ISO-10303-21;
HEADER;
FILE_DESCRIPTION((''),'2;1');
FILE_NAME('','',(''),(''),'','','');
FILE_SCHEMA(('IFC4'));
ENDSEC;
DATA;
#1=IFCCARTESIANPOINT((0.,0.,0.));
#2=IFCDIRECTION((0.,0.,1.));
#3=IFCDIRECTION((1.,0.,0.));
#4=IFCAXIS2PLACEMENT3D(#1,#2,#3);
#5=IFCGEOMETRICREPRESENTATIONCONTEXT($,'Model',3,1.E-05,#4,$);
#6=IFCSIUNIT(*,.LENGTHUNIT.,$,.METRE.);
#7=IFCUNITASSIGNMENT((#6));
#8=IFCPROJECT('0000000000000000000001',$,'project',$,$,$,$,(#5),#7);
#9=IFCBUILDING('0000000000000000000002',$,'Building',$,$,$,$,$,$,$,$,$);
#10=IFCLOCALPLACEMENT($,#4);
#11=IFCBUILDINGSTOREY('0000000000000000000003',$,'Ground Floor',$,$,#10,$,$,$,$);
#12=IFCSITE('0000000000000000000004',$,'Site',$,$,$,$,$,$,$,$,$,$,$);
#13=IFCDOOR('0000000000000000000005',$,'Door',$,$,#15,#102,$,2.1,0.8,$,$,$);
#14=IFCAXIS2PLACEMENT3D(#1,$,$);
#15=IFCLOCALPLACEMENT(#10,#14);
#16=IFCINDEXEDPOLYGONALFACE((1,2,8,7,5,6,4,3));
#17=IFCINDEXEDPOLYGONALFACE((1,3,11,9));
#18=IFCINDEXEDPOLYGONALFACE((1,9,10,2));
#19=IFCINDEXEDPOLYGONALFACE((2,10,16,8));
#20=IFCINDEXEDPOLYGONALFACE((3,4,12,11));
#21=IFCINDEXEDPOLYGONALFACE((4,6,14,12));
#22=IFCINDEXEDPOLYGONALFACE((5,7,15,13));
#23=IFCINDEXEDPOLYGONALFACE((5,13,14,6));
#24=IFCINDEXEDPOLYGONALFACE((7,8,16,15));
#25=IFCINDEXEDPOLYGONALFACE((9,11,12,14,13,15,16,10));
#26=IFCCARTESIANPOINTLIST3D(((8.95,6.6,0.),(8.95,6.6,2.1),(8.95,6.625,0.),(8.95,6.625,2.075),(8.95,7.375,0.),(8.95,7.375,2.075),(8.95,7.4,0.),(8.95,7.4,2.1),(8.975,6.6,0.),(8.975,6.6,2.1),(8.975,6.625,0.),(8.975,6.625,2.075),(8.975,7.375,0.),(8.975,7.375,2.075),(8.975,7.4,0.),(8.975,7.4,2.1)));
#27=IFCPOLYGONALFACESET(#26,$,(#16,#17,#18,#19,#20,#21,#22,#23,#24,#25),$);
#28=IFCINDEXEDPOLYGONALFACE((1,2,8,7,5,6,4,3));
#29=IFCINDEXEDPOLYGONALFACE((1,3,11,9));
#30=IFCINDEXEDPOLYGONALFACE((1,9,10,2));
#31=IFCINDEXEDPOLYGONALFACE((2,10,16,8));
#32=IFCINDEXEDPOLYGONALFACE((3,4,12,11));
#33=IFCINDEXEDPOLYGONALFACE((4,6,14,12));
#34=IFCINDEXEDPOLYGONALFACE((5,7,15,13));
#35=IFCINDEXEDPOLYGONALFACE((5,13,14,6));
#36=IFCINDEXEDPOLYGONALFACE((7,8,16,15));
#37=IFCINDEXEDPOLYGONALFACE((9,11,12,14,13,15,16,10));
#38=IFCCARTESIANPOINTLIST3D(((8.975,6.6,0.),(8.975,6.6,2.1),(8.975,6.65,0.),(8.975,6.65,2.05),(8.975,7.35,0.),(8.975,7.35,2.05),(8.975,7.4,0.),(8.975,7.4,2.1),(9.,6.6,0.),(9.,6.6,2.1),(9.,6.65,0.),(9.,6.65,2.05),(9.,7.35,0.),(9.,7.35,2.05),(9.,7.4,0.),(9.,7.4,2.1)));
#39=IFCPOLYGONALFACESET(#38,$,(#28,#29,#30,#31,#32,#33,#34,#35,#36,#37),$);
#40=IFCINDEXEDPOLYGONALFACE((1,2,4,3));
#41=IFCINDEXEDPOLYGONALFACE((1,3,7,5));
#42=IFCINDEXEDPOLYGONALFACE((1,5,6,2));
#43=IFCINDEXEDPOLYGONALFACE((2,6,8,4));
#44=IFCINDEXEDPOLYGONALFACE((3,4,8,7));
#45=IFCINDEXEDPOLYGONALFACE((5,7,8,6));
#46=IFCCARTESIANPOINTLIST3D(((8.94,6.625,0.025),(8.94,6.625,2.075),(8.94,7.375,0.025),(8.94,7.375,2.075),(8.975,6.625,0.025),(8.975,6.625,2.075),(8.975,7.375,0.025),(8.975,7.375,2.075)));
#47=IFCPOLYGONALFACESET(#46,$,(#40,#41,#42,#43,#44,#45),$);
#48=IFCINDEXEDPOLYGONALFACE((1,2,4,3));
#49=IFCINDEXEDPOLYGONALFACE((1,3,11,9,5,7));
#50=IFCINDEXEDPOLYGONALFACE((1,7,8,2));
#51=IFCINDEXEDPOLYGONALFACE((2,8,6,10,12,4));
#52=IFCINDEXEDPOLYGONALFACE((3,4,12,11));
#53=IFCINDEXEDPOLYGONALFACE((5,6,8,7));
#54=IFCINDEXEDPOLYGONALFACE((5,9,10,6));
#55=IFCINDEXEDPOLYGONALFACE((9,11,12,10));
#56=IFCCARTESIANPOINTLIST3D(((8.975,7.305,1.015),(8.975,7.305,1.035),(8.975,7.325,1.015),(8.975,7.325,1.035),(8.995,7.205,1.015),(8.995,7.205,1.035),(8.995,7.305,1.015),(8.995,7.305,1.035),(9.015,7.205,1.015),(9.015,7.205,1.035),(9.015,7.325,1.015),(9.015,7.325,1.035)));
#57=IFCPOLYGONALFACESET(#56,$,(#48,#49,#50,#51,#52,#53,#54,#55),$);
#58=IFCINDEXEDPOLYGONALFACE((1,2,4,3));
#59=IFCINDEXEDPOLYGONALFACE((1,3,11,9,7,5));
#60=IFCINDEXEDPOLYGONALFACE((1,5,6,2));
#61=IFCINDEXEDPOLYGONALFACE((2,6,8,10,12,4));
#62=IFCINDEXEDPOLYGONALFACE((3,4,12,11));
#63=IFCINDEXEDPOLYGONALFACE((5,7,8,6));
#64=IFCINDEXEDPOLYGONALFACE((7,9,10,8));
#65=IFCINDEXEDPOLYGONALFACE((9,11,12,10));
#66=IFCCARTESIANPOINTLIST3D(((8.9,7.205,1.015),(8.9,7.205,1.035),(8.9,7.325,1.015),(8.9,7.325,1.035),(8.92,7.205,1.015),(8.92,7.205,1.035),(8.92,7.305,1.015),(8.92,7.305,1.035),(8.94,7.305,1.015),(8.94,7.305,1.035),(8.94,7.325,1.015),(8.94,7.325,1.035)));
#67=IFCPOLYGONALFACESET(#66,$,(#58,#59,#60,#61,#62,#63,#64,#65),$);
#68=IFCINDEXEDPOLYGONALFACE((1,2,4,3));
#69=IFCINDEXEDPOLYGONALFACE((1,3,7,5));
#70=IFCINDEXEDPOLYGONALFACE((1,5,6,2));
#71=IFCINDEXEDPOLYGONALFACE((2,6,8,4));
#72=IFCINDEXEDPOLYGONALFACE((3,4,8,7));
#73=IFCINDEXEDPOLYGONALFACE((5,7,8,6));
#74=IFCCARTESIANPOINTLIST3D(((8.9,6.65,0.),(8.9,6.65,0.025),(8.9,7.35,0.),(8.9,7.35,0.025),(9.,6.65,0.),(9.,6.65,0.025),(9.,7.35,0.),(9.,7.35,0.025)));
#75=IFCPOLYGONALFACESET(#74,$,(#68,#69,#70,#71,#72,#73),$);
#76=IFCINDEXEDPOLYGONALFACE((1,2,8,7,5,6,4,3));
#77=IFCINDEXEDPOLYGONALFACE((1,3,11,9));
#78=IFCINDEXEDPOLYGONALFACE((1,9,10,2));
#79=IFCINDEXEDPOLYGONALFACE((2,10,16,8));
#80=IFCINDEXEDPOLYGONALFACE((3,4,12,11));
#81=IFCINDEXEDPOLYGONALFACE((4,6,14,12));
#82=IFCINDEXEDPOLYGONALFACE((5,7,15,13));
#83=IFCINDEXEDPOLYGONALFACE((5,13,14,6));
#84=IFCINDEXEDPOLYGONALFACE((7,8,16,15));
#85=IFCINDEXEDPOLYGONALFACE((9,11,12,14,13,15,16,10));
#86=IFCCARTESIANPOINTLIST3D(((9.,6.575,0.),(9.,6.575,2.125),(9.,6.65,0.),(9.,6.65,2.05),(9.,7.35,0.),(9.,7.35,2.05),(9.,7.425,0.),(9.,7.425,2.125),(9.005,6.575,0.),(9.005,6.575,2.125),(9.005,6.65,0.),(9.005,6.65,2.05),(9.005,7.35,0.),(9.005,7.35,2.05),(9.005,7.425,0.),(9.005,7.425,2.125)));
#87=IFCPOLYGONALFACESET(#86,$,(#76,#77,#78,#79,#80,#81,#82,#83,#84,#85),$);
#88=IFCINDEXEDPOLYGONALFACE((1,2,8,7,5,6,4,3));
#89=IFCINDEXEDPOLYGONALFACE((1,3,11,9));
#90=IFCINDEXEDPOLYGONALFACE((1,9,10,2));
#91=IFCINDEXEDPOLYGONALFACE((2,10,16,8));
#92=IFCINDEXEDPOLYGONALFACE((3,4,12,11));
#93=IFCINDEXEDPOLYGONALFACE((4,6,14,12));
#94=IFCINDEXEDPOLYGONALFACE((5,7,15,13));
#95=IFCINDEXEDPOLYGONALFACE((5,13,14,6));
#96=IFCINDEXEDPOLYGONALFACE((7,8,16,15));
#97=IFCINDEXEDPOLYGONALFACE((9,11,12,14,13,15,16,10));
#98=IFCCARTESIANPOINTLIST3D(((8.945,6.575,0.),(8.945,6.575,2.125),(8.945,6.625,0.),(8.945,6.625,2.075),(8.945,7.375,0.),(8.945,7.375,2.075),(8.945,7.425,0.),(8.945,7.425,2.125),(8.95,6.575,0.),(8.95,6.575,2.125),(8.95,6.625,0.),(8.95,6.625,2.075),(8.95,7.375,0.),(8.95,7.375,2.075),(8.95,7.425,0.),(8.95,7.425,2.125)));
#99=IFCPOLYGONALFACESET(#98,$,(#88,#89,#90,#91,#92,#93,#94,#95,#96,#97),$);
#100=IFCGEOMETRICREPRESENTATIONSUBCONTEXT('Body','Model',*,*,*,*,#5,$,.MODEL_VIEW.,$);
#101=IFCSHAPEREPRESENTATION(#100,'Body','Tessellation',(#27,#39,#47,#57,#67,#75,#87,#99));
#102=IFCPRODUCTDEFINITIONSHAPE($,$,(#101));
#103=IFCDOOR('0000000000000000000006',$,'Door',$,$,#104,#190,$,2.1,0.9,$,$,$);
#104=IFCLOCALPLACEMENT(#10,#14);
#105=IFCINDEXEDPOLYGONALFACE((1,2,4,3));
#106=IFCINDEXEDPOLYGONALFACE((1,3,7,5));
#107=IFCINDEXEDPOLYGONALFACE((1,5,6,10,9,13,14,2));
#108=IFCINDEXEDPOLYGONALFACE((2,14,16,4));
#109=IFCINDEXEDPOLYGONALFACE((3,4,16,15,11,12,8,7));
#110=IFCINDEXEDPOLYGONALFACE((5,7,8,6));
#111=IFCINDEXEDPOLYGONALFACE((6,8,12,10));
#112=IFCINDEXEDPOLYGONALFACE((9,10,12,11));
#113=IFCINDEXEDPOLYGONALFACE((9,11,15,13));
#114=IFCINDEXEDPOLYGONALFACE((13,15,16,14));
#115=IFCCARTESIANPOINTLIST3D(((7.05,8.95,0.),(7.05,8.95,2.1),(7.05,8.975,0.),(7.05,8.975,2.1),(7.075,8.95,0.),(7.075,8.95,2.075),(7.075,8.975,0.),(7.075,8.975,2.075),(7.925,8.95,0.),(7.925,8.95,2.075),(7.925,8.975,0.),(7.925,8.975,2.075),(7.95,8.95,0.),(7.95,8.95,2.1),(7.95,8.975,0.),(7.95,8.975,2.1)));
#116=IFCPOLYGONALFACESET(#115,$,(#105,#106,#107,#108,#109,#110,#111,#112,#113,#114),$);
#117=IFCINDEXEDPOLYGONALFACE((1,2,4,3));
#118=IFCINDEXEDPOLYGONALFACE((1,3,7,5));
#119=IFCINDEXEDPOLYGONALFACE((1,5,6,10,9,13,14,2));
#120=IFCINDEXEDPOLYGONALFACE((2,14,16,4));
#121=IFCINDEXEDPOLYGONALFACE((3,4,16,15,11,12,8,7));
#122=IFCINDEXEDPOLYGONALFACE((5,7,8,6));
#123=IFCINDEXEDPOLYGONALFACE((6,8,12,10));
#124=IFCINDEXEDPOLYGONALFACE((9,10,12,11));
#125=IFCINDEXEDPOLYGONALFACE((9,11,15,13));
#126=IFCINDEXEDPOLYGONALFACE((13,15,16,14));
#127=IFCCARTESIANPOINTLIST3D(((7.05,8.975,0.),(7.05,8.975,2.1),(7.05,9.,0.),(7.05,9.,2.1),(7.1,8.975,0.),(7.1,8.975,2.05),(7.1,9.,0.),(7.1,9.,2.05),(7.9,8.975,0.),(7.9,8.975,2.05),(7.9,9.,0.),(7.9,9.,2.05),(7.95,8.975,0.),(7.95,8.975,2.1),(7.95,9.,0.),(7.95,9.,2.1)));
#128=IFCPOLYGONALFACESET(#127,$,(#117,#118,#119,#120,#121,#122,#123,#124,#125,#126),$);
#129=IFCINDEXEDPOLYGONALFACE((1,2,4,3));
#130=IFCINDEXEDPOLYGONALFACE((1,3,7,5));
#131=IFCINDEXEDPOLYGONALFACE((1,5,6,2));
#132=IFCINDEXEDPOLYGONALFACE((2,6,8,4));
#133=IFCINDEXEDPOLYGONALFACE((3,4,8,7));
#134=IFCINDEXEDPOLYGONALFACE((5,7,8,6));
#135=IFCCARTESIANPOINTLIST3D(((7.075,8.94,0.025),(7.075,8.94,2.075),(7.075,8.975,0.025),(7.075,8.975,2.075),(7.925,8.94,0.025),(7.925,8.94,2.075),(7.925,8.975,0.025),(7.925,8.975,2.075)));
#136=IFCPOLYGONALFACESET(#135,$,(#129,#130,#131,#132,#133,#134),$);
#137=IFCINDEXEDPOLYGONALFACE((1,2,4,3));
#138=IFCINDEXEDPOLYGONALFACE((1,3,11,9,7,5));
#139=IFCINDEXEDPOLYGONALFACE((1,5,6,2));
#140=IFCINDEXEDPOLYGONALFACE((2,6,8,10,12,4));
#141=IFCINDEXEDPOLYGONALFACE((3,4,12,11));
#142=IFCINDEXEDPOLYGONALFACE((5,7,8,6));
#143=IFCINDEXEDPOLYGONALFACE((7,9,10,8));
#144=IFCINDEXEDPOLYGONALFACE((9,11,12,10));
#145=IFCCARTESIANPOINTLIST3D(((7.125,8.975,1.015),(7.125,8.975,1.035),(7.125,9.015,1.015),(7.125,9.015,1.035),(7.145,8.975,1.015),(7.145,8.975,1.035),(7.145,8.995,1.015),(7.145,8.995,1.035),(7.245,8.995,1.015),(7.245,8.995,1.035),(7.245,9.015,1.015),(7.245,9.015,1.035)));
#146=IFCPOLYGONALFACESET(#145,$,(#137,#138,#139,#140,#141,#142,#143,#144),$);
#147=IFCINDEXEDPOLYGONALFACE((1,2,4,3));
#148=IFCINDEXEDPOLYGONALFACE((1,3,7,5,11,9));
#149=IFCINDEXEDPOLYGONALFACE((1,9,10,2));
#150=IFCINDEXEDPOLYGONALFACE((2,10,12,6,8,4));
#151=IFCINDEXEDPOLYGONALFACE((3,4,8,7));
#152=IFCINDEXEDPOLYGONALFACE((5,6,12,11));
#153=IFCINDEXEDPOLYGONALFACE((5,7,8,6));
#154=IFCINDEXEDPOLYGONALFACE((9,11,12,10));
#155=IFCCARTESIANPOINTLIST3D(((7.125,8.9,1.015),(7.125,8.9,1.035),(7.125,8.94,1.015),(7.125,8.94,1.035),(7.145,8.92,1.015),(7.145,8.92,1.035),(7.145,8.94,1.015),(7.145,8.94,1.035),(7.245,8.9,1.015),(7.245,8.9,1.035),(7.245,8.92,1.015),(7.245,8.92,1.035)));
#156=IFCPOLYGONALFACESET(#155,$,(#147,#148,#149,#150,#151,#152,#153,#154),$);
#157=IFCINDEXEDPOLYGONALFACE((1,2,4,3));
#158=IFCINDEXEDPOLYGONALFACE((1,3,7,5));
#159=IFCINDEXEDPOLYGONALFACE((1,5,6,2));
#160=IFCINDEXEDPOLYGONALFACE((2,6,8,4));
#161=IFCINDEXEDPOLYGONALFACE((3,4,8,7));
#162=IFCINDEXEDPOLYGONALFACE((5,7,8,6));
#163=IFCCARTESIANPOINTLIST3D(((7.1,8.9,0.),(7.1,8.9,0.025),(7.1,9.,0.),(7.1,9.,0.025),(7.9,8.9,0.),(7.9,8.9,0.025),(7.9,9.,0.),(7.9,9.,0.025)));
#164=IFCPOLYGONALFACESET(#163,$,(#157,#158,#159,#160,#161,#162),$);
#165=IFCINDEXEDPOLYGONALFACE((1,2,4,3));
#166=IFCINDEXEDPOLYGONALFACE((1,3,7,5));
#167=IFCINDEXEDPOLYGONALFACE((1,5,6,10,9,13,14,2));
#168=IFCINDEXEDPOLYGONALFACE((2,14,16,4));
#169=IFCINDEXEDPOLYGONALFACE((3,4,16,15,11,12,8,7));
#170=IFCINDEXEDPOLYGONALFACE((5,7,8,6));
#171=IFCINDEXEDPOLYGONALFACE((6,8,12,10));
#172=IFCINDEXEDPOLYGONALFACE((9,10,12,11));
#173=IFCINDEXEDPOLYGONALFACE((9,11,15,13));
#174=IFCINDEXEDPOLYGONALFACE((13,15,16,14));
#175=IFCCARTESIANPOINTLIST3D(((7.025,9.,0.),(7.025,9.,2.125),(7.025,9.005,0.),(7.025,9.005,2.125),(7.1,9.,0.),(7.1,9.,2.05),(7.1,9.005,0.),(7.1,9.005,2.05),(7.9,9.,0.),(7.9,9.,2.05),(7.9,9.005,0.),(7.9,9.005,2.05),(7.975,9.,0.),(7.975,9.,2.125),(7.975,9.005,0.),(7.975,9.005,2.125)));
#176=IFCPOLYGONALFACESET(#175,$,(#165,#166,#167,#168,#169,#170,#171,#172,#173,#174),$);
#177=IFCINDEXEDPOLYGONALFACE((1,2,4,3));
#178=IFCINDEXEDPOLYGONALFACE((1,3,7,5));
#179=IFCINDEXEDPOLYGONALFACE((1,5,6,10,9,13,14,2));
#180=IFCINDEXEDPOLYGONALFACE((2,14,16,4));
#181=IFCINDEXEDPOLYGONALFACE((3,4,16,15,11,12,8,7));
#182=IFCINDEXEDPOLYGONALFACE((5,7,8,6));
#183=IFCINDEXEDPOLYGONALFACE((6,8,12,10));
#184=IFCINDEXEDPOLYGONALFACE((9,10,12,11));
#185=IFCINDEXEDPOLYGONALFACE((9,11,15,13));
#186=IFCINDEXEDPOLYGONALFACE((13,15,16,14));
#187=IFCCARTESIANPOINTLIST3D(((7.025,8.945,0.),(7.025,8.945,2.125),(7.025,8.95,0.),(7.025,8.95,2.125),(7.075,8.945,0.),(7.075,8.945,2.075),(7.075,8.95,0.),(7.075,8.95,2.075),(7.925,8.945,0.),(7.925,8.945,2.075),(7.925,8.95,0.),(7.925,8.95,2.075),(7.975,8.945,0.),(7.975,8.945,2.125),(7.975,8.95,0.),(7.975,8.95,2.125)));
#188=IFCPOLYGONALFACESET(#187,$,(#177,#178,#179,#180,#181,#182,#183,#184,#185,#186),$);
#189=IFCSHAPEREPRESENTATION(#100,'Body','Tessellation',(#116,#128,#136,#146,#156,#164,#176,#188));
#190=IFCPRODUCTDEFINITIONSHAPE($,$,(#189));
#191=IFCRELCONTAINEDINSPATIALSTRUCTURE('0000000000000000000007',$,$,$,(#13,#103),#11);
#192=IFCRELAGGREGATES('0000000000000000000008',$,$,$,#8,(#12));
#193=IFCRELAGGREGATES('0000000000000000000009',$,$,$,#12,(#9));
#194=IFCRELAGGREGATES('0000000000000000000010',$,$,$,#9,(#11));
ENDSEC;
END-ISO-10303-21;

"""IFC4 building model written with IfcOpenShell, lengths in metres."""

from ifc_helpers import new_model, si_unit, frame, origin_with_axes, place, context, subcontext, project, spatial, line, indexed_curve, outline, extrude, element, save


model = new_model("IFC4")

# Units and contexts
model_context = context("Model", 3, precision=1e-05, world=origin_with_axes())
body_context = subcontext(model_context, "Body", "Model", "MODEL_VIEW")
ifc_project = project(units=[si_unit("LENGTHUNIT", "METRE")], contexts=[model_context])

# Site, building, storey
site = spatial("IfcSite", under=ifc_project, Name="Site")
building = spatial("IfcBuilding", under=site, Name="Building")
storey_placement = place(None, origin_with_axes())
storey = spatial("IfcBuildingStorey", under=building, at=storey_placement, Name="Ground Floor")

# Doors
door_1_placement = place(storey_placement, frame((9.0, 6.6, 0.0), z_axis=(0.0, 0.0, 1.0), x_axis=(0.0, 1.0, 0.0)))
element("IfcDoor", 1, at=door_1_placement, inside=storey, Name="Door", OverallHeight=2.1, OverallWidth=0.8, context=body_context, shape_type="SweptSolid", body=[
    extrude(outline(indexed_curve([(0.0, 0.0), (0.0, 2.1), (0.8, 2.1), (0.8, 0.0), (0.775, 0.0), (0.775, 2.075), (0.025, 2.075), (0.025, 0.0)], segments=[line(1, 2, 3, 4, 5, 6, 7, 8, 1)])), frame((0.0, 0.025, 0.0), z_axis=(0.0, -1.0, 0.0), x_axis=(1.0, 0.0, 0.0)), (0.0, 0.0, -1.0), 0.025),
    extrude(outline(indexed_curve([(0.0, 0.0), (0.0, 2.1), (0.8, 2.1), (0.8, 0.0), (0.75, 0.0), (0.75, 2.05), (0.05, 2.05), (0.05, 0.0)], segments=[line(1, 2, 3, 4, 5, 6, 7, 8, 1)])), frame((0.0, 0.0, 0.0), z_axis=(0.0, -1.0, 0.0), x_axis=(1.0, 0.0, 0.0)), (0.0, 0.0, -1.0), 0.025),
    extrude(outline(indexed_curve([(0.0, 0.0), (0.75, 0.0), (0.75, 0.035), (0.0, 0.035)], segments=[line(1, 2, 3, 4, 1)])), frame((0.025, 0.025, 0.025), z_axis=(0.0, 0.0, 1.0), x_axis=(1.0, 0.0, 0.0)), (0.0, 0.0, 1.0), 2.05),
    extrude(outline(indexed_curve([(0.0, 0.0), (0.0, -0.04), (-0.12, -0.04), (-0.12, -0.02), (-0.02, -0.02), (-0.02, 0.0)], segments=[line(1, 2, 3, 4, 5, 6, 1)])), frame((0.725, 0.025, 1.015), z_axis=(0.0, 0.0, 1.0), x_axis=(1.0, 0.0, 0.0)), (0.0, 0.0, 1.0), 0.02),
    extrude(outline(indexed_curve([(0.0, 0.0), (0.0, 0.04), (-0.12, 0.04), (-0.12, 0.02), (-0.02, 0.02), (-0.02, 0.0)], segments=[line(1, 2, 3, 4, 5, 6, 1)])), frame((0.725, 0.06, 1.015), z_axis=(0.0, 0.0, 1.0), x_axis=(1.0, 0.0, 0.0)), (0.0, 0.0, 1.0), 0.02),
    extrude(outline(indexed_curve([(0.0, 0.0), (0.7, 0.0), (0.7, 0.1), (0.0, 0.1)], segments=[line(1, 2, 3, 4, 1)])), frame((0.05, 0.0, 0.0), z_axis=(0.0, 0.0, 1.0), x_axis=(1.0, 0.0, 0.0)), (0.0, 0.0, 1.0), 0.025),
    extrude(outline(indexed_curve([(0.0, 0.0), (0.0, 2.125), (0.85, 2.125), (0.85, 0.0), (0.775, 0.0), (0.775, 2.05), (0.075, 2.05), (0.075, 0.0)], segments=[line(1, 2, 3, 4, 5, 6, 7, 8, 1)])), frame((-0.025, -0.005, 0.0), z_axis=(0.0, -1.0, 0.0), x_axis=(1.0, 0.0, 0.0)), (0.0, 0.0, -1.0), 0.005),
    extrude(outline(indexed_curve([(0.0, 0.0), (0.0, 2.125), (0.85, 2.125), (0.85, 0.0), (0.8, 0.0), (0.8, 2.075), (0.05, 2.075), (0.05, 0.0)], segments=[line(1, 2, 3, 4, 5, 6, 7, 8, 1)])), frame((-0.025, 0.05, 0.0), z_axis=(0.0, -1.0, 0.0), x_axis=(1.0, 0.0, 0.0)), (0.0, 0.0, -1.0), 0.005),
])
door_2_placement = place(storey_placement, frame((7.95, 9.0, 0.0), z_axis=(0.0, 0.0, 1.0), x_axis=(-1.0, 0.0, 0.0)))
element("IfcDoor", 2, at=door_2_placement, inside=storey, Name="Door", OverallHeight=2.1, OverallWidth=0.9, context=body_context, shape_type="SweptSolid", body=[
    extrude(outline(indexed_curve([(0.0, 0.0), (0.0, 2.1), (0.9, 2.1), (0.9, 0.0), (0.875, 0.0), (0.875, 2.075), (0.025, 2.075), (0.025, 0.0)], segments=[line(1, 2, 3, 4, 5, 6, 7, 8, 1)])), frame((0.0, 0.025, 0.0), z_axis=(0.0, -1.0, 0.0), x_axis=(1.0, 0.0, 0.0)), (0.0, 0.0, -1.0), 0.025),
    extrude(outline(indexed_curve([(0.0, 0.0), (0.0, 2.1), (0.9, 2.1), (0.9, 0.0), (0.85, 0.0), (0.85, 2.05), (0.05, 2.05), (0.05, 0.0)], segments=[line(1, 2, 3, 4, 5, 6, 7, 8, 1)])), frame((0.0, 0.0, 0.0), z_axis=(0.0, -1.0, 0.0), x_axis=(1.0, 0.0, 0.0)), (0.0, 0.0, -1.0), 0.025),
    extrude(outline(indexed_curve([(0.0, 0.0), (0.85, 0.0), (0.85, 0.035), (0.0, 0.035)], segments=[line(1, 2, 3, 4, 1)])), frame((0.025, 0.025, 0.025), z_axis=(0.0, 0.0, 1.0), x_axis=(1.0, 0.0, 0.0)), (0.0, 0.0, 1.0), 2.05),
    extrude(outline(indexed_curve([(0.0, 0.0), (0.0, -0.04), (-0.12, -0.04), (-0.12, -0.02), (-0.02, -0.02), (-0.02, 0.0)], segments=[line(1, 2, 3, 4, 5, 6, 1)])), frame((0.825, 0.025, 1.015), z_axis=(0.0, 0.0, 1.0), x_axis=(1.0, 0.0, 0.0)), (0.0, 0.0, 1.0), 0.02),
    extrude(outline(indexed_curve([(0.0, 0.0), (0.0, 0.04), (-0.12, 0.04), (-0.12, 0.02), (-0.02, 0.02), (-0.02, 0.0)], segments=[line(1, 2, 3, 4, 5, 6, 1)])), frame((0.825, 0.06, 1.015), z_axis=(0.0, 0.0, 1.0), x_axis=(1.0, 0.0, 0.0)), (0.0, 0.0, 1.0), 0.02),
    extrude(outline(indexed_curve([(0.0, 0.0), (0.8, 0.0), (0.8, 0.1), (0.0, 0.1)], segments=[line(1, 2, 3, 4, 1)])), frame((0.05, 0.0, 0.0), z_axis=(0.0, 0.0, 1.0), x_axis=(1.0, 0.0, 0.0)), (0.0, 0.0, 1.0), 0.025),
    extrude(outline(indexed_curve([(0.0, 0.0), (0.0, 2.125), (0.95, 2.125), (0.95, 0.0), (0.875, 0.0), (0.875, 2.05), (0.075, 2.05), (0.075, 0.0)], segments=[line(1, 2, 3, 4, 5, 6, 7, 8, 1)])), frame((-0.025, -0.005, 0.0), z_axis=(0.0, -1.0, 0.0), x_axis=(1.0, 0.0, 0.0)), (0.0, 0.0, -1.0), 0.005),
    extrude(outline(indexed_curve([(0.0, 0.0), (0.0, 2.125), (0.95, 2.125), (0.95, 0.0), (0.9, 0.0), (0.9, 2.075), (0.05, 2.075), (0.05, 0.0)], segments=[line(1, 2, 3, 4, 5, 6, 7, 8, 1)])), frame((-0.025, 0.05, 0.0), z_axis=(0.0, -1.0, 0.0), x_axis=(1.0, 0.0, 0.0)), (0.0, 0.0, -1.0), 0.005),
])

save(model, "model.ifc")
